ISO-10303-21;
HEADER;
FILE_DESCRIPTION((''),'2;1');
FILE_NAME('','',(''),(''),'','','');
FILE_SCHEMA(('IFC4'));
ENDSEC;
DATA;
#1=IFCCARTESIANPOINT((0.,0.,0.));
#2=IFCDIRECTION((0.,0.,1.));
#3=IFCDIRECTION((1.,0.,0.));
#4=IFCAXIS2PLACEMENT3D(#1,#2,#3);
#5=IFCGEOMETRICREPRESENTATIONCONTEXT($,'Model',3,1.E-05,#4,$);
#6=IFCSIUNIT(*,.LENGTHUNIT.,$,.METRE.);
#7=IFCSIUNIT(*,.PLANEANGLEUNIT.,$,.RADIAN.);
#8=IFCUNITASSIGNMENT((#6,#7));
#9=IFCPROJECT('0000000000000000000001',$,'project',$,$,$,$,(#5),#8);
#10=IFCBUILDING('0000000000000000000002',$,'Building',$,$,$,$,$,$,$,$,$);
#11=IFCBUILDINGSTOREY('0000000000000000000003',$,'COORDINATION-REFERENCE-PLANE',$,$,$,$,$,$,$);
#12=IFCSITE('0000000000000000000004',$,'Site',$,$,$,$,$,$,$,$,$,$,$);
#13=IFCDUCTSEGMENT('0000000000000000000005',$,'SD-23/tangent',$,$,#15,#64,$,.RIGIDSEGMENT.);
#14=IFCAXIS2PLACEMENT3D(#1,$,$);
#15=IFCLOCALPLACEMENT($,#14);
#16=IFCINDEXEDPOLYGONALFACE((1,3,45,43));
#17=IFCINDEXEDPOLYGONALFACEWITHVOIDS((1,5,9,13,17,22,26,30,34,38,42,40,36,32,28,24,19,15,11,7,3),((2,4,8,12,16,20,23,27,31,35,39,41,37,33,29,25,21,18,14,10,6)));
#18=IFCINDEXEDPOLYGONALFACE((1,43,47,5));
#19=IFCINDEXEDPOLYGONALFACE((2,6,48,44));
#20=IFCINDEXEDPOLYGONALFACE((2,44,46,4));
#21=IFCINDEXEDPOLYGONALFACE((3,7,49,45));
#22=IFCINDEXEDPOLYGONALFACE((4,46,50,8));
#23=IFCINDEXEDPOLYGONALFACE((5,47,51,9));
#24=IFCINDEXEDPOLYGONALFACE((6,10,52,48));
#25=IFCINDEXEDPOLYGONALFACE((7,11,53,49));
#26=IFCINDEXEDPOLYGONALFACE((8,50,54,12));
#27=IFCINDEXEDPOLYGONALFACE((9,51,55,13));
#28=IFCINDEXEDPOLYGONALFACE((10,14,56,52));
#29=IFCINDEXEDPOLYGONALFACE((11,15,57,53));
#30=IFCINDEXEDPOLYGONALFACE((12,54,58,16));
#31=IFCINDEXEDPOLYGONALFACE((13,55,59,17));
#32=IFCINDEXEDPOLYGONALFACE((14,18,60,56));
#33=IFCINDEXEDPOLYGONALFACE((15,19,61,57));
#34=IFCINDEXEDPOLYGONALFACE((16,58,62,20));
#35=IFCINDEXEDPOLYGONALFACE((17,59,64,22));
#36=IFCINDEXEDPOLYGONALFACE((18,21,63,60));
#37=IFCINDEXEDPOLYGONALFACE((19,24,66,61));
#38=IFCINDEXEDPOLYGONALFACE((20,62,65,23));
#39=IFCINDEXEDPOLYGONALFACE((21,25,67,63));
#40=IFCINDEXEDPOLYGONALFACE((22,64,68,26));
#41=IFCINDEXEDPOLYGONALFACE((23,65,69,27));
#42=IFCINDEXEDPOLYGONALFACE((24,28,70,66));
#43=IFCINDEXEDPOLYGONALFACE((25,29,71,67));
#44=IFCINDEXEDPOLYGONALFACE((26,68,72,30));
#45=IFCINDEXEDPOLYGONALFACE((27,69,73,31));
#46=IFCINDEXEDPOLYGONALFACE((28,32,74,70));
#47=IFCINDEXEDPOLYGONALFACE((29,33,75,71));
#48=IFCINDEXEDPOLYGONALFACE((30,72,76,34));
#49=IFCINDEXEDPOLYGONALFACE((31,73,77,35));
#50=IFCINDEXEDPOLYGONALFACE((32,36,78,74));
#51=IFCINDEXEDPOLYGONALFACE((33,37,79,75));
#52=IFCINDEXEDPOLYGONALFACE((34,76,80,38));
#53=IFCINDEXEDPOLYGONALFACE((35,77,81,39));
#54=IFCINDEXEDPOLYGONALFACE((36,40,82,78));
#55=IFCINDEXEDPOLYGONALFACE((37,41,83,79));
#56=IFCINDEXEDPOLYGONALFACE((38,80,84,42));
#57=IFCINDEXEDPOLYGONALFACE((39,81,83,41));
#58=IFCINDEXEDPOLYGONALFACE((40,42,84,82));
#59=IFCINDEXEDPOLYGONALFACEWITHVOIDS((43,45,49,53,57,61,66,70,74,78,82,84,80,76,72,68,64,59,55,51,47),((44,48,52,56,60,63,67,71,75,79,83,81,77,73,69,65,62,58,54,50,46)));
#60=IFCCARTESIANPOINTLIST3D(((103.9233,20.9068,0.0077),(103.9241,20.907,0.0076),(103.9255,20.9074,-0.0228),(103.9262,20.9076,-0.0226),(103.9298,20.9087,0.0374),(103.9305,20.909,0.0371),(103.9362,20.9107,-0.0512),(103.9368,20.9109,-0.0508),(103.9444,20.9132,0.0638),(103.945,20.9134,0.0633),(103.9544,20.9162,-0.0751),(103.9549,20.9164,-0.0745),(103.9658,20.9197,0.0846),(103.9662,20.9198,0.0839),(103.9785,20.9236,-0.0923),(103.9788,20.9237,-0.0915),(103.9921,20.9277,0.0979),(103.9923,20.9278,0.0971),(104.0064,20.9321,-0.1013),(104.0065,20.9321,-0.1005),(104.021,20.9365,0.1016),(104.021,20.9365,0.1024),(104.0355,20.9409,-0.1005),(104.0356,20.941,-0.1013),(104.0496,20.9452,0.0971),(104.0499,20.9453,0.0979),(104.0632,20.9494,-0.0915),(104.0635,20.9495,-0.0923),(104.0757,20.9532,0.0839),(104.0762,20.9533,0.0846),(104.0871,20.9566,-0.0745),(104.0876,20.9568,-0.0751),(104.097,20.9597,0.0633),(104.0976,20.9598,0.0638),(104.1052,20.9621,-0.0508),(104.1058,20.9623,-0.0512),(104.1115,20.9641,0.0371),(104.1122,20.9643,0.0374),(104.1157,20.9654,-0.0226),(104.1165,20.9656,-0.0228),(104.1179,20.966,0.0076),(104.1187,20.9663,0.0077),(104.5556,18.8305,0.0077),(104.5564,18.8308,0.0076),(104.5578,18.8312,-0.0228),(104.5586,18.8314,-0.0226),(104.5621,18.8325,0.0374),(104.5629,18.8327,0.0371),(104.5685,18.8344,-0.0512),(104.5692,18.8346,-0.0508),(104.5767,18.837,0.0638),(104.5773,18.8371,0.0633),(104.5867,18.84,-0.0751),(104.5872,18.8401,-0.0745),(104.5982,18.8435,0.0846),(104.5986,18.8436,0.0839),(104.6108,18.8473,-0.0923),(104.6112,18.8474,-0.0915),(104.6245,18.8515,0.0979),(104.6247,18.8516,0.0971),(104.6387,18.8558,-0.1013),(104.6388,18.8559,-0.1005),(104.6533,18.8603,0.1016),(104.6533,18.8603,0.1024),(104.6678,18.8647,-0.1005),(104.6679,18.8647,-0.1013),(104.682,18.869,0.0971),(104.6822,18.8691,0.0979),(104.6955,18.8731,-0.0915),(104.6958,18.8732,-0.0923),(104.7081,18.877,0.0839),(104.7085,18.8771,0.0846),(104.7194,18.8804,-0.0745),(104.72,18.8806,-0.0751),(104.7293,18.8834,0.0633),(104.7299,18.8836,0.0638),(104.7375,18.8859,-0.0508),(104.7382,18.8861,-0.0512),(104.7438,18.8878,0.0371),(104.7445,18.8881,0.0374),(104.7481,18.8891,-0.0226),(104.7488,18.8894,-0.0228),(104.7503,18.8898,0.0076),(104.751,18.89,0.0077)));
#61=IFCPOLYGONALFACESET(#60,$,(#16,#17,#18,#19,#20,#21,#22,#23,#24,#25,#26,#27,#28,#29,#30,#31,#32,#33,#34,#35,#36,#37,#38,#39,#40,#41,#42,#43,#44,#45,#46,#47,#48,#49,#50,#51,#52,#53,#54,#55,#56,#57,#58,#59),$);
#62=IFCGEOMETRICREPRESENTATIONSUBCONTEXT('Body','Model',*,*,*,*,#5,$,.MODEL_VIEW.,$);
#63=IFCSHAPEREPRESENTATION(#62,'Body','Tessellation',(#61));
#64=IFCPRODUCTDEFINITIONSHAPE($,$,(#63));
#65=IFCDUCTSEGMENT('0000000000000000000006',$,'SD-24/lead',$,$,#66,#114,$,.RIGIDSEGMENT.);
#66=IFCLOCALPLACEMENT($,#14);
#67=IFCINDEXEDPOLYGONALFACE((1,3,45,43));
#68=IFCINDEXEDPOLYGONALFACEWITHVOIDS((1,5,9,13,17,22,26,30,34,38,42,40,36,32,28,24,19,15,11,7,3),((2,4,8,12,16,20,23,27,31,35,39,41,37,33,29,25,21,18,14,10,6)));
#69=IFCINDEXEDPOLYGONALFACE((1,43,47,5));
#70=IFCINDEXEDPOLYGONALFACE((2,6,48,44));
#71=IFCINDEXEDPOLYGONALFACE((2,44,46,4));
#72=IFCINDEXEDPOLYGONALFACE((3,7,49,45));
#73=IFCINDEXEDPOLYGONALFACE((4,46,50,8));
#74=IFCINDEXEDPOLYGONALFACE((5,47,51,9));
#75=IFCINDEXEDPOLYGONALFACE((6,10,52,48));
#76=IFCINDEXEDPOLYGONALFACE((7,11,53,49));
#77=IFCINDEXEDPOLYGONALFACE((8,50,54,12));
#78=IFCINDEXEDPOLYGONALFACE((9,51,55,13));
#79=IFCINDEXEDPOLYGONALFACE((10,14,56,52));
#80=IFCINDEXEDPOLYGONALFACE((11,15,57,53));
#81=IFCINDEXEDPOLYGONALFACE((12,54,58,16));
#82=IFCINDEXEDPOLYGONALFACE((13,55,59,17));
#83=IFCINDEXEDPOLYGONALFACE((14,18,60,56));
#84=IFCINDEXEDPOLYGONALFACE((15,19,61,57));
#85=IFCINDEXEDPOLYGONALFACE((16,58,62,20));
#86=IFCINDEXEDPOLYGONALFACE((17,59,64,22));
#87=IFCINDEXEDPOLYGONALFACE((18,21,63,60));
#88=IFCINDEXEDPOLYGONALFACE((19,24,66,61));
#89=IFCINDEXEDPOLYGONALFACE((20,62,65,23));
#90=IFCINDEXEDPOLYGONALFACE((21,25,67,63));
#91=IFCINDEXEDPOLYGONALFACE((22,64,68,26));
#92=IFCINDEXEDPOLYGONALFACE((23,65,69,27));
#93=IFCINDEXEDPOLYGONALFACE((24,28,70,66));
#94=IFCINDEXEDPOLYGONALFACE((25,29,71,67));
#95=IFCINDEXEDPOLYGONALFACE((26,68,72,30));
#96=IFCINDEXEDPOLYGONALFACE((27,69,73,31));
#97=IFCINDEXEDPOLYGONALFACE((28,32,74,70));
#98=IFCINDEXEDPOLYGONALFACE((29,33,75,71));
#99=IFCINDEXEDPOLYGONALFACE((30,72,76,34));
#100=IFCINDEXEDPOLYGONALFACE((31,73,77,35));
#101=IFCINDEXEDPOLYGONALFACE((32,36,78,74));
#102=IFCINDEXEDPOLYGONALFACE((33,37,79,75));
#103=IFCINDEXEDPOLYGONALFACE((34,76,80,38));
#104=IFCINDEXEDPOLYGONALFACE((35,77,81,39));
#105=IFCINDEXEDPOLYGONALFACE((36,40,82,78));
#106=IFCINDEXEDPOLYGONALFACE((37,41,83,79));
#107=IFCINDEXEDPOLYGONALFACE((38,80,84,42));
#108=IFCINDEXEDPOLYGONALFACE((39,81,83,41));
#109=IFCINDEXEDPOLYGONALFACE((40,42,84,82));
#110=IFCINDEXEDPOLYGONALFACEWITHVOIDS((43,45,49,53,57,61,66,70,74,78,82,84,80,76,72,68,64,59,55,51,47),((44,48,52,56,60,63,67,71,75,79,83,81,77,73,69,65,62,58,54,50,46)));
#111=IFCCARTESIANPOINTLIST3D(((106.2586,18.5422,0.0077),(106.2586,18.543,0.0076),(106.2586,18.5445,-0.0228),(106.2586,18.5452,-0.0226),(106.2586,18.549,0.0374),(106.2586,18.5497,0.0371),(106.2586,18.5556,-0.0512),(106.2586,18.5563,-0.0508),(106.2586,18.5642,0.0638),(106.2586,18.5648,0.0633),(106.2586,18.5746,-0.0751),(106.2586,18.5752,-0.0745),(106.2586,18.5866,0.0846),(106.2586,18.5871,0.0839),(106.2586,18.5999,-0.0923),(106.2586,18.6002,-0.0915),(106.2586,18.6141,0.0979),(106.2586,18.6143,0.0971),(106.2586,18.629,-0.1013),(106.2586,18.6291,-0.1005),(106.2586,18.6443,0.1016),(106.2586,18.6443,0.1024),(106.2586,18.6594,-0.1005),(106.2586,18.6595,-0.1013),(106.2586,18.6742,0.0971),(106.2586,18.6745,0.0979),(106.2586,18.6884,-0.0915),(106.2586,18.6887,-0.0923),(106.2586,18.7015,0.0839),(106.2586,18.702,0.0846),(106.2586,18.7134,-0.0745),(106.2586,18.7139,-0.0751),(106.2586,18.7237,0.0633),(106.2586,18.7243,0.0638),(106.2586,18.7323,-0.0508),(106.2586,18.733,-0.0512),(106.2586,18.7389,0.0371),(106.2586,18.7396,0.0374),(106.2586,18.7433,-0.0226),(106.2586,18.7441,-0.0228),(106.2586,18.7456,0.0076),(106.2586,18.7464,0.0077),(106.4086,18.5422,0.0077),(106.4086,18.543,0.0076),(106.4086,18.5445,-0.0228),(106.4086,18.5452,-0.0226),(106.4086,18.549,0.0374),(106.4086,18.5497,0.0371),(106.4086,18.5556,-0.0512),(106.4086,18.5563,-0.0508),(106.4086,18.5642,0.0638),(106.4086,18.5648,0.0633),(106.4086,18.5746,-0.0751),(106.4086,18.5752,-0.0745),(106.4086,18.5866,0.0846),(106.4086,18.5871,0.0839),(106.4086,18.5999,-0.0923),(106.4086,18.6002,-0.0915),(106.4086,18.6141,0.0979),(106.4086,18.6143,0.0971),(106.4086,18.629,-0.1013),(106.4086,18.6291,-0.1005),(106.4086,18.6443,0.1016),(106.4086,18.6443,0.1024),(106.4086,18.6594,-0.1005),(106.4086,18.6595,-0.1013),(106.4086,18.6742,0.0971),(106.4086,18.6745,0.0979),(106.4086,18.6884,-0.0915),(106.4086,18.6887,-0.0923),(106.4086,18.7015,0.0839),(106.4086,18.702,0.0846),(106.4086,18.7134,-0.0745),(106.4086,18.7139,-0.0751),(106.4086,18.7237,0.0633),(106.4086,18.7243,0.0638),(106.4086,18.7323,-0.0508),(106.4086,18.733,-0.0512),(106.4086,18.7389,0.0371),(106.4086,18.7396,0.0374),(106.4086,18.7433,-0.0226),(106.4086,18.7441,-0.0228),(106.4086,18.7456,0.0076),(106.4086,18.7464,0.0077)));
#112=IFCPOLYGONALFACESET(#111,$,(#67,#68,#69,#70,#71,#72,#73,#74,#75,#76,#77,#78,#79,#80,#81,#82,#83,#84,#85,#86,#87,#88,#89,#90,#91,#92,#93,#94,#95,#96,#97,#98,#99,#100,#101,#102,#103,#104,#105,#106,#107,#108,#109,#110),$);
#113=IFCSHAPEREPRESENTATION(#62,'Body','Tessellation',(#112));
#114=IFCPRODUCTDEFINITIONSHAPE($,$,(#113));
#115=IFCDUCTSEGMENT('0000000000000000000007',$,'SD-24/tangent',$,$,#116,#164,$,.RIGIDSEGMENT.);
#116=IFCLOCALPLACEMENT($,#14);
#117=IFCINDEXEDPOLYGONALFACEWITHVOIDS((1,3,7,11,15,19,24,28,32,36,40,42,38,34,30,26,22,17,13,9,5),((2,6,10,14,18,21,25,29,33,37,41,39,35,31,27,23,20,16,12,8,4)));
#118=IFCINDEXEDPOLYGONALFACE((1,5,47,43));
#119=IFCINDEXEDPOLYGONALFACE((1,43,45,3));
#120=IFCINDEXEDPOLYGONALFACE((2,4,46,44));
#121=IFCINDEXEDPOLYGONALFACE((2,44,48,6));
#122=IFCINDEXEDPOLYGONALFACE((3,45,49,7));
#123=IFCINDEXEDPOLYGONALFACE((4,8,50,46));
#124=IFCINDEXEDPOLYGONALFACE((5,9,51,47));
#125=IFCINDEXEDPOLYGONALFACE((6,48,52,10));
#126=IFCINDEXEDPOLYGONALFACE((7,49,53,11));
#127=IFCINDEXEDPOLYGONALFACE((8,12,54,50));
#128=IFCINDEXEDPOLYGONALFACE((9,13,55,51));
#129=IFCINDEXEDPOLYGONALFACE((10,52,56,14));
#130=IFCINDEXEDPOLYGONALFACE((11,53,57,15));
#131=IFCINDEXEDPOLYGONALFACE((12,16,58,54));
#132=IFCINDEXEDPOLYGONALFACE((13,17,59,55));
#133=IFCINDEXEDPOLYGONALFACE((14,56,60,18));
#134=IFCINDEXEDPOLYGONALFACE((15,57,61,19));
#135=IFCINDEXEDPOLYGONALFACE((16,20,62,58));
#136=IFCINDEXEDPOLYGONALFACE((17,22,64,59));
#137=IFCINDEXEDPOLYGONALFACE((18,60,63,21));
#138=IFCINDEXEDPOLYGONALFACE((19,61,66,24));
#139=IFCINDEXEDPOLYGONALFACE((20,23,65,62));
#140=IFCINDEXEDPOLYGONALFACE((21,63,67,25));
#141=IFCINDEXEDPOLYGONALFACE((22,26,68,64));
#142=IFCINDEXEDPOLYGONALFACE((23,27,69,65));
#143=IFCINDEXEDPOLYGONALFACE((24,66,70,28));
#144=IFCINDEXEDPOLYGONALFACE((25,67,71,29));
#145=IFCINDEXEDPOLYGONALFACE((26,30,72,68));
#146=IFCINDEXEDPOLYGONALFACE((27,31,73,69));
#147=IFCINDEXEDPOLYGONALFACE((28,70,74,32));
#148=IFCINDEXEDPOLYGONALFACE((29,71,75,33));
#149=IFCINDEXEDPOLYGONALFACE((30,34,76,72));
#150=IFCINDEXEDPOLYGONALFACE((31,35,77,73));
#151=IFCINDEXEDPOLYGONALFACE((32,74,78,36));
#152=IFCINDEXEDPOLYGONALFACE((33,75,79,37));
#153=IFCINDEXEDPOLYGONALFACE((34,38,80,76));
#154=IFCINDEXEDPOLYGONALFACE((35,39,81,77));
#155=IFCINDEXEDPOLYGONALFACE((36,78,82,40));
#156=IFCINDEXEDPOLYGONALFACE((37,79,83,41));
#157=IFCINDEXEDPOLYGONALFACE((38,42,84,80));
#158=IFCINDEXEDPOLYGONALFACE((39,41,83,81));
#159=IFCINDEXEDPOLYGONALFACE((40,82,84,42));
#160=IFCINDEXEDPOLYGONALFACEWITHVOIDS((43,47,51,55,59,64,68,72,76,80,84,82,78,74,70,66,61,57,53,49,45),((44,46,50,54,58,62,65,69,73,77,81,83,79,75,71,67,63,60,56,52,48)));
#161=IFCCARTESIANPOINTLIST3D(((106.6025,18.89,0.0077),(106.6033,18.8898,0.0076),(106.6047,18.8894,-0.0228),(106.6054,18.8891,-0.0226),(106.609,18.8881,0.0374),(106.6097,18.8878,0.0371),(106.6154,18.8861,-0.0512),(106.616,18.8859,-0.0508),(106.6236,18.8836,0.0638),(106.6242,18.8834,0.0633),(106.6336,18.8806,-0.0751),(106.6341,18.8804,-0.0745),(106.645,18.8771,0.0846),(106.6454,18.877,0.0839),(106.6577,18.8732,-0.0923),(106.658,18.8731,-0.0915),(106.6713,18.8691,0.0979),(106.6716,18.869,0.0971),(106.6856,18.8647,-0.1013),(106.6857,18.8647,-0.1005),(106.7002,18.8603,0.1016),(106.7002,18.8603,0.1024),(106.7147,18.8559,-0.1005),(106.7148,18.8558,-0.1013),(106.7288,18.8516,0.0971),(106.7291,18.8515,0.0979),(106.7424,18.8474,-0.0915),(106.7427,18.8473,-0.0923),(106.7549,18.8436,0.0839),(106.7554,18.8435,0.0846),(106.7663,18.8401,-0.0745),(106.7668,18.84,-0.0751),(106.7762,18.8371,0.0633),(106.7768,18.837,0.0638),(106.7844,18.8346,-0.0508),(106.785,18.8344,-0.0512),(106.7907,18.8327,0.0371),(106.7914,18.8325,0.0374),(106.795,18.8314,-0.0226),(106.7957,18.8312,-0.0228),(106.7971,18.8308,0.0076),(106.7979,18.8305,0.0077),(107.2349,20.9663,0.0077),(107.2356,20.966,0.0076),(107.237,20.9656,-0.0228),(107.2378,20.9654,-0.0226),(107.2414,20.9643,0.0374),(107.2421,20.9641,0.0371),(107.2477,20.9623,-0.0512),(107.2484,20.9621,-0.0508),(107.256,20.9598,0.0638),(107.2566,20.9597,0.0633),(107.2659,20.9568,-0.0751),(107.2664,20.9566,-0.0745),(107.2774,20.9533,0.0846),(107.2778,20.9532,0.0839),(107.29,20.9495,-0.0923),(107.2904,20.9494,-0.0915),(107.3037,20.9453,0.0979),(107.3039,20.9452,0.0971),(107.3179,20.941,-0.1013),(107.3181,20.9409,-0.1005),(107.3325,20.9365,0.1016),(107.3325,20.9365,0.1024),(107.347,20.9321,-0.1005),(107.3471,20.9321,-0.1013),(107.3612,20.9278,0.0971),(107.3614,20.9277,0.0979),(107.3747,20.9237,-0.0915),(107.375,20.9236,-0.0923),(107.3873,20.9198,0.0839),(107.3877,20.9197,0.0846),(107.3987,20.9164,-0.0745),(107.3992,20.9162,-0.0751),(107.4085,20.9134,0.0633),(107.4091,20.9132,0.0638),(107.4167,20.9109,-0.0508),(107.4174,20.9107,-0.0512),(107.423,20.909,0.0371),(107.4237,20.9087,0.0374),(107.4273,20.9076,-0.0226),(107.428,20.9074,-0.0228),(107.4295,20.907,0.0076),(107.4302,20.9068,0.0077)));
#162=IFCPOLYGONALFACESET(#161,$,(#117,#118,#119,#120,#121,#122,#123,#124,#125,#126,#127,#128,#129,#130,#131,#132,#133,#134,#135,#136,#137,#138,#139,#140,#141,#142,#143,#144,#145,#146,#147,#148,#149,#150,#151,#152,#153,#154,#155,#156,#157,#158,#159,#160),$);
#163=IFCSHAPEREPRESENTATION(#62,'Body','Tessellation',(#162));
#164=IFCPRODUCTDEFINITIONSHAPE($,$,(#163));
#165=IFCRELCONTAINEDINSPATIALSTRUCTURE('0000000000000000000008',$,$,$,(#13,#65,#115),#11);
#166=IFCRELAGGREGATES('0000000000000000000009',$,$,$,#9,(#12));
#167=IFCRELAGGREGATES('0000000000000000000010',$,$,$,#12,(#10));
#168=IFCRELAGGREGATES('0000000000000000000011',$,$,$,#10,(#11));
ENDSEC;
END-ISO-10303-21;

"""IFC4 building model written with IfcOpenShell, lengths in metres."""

from ifc_helpers import new_model, si_unit, frame, origin_with_axes, place, context, subcontext, project, spatial, hollow_circle, extrude, element, save


model = new_model("IFC4")

# Units and contexts
model_context = context("Model", 3, precision=1e-05, world=origin_with_axes())
body_context_1 = subcontext(model_context, "Body", "Model", "MODEL_VIEW")
ifc_project = project(units=[si_unit("LENGTHUNIT", "METRE"), si_unit("PLANEANGLEUNIT", "RADIAN")], contexts=[model_context])

# Site, building, storey
site = spatial("IfcSite", under=ifc_project, Name="Site")
building = spatial("IfcBuilding", under=site, Name="Building")
storey = spatial("IfcBuildingStorey", under=building, Name="COORDINATION-REFERENCE-PLANE")

# Duct segment
duct_segment_1_placement = place(None, frame((104.6533, 18.8603, 0.0), z_axis=(-0.291351, 0.956616, 0.0), x_axis=(0.0, 0.0, 1.0)))
element("IfcDuctSegment", 1, at=duct_segment_1_placement, inside=storey, Name="SD-23/tangent", PredefinedType="RIGIDSEGMENT", context=body_context_1, shape_type="SweptSolid", body=[
    extrude(hollow_circle(Radius=0.1024, WallThickness=0.0008), origin_with_axes(), (0.0, 0.0, 1.0), 2.1704),
])

# Duct segment
duct_segment_2_placement = place(None, frame((106.2586, 18.6443, 0.0), z_axis=(1.0, 0.0, 0.0), x_axis=(0.0, 0.0, 1.0)))
element("IfcDuctSegment", 2, at=duct_segment_2_placement, inside=storey, Name="SD-24/lead", PredefinedType="RIGIDSEGMENT", context=body_context_1, shape_type="SweptSolid", body=[
    extrude(hollow_circle(Radius=0.1024, WallThickness=0.0008), origin_with_axes(), (0.0, 0.0, 1.0), 0.15),
])

# Duct segment
duct_segment_3_placement = place(None, frame((106.7002, 18.8603, 0.0), z_axis=(0.291351, 0.956616, 0.0), x_axis=(0.0, 0.0, 1.0)))
element("IfcDuctSegment", 3, at=duct_segment_3_placement, inside=storey, Name="SD-24/tangent", PredefinedType="RIGIDSEGMENT", context=body_context_1, shape_type="SweptSolid", body=[
    extrude(hollow_circle(Radius=0.1024, WallThickness=0.0008), origin_with_axes(), (0.0, 0.0, 1.0), 2.1704),
])

save(model, "model.ifc")
